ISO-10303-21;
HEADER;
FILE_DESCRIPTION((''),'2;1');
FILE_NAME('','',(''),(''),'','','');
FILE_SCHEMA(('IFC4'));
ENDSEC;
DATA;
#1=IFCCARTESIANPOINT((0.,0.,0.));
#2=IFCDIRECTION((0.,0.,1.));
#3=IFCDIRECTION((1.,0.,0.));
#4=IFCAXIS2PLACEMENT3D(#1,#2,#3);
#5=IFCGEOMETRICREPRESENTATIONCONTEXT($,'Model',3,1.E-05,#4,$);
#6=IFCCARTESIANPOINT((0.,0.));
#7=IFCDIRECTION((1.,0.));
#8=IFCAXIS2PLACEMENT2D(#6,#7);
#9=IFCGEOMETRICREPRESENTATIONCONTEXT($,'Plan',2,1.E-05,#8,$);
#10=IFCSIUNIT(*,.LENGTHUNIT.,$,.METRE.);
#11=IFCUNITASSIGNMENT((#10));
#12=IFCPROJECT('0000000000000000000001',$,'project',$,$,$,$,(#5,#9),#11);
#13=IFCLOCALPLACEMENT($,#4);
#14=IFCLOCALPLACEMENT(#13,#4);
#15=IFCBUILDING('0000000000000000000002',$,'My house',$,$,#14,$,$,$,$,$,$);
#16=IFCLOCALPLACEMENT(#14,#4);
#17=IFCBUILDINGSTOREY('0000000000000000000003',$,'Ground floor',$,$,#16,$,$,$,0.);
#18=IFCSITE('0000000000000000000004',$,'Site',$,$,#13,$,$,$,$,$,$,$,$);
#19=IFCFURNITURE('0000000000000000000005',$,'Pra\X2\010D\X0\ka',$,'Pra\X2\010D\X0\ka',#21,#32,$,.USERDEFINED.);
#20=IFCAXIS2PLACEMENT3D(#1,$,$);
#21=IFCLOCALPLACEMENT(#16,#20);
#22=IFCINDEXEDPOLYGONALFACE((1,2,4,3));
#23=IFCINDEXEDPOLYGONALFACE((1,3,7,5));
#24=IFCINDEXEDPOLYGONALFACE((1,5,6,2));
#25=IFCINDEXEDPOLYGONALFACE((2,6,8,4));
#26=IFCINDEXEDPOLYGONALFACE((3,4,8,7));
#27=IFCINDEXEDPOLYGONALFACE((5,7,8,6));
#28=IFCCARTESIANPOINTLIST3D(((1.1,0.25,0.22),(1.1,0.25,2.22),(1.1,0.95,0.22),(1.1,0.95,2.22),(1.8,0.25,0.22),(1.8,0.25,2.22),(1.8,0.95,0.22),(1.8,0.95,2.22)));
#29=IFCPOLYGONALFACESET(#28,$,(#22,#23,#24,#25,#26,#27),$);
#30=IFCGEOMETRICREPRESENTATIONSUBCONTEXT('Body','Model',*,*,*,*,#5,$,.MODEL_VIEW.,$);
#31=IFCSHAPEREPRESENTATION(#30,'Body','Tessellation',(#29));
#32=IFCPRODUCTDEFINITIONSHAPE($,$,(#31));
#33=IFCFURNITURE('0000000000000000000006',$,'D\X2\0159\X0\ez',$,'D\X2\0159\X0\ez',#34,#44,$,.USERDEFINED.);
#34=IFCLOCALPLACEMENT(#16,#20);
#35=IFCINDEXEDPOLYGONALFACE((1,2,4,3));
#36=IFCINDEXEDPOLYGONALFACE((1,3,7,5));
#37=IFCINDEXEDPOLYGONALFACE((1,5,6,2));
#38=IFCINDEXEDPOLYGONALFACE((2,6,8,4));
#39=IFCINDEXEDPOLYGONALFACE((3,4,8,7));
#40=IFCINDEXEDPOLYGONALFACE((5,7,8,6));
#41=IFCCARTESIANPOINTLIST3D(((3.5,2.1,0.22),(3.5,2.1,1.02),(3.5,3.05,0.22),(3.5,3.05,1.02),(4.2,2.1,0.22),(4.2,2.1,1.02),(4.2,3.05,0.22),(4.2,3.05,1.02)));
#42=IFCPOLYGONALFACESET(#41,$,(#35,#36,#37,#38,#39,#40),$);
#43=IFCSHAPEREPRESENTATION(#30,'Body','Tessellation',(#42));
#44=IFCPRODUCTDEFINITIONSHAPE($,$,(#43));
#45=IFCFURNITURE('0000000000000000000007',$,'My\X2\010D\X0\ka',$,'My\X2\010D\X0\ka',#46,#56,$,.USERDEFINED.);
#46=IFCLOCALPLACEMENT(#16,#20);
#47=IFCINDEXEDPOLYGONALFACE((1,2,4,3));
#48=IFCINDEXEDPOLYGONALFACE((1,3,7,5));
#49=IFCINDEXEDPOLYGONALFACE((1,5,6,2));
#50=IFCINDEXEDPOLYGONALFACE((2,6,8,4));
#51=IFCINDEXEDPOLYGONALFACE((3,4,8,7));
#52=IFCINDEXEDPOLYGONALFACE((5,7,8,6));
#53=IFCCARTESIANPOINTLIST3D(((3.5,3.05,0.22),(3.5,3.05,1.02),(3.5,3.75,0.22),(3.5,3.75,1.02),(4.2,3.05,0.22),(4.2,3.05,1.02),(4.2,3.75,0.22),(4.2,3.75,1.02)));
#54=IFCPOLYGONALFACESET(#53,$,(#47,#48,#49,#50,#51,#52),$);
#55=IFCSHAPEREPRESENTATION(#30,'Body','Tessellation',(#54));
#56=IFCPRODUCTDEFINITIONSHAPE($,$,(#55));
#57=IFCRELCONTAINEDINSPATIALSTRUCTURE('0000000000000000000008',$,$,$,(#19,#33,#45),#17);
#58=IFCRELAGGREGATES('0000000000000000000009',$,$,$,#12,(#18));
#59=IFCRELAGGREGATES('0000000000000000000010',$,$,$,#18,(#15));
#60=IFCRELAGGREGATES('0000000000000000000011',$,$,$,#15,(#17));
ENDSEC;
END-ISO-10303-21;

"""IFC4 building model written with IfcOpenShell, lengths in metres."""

from ifc_helpers import new_model, entity, si_unit, frame, origin_with_axes, origin_2d_with_axis, place, context, subcontext, project, spatial, indexed_curve, outline, extrude, shape, element, save


model = new_model("IFC4")

# Units and contexts
model_context = context("Model", 3, precision=1e-05, world=origin_with_axes())
plan_context = context("Plan", 2, precision=1e-05, world=origin_2d_with_axis())
body_context_1 = subcontext(model_context, "Body", "Model", "MODEL_VIEW")
body_context_2 = subcontext(plan_context, "Body", "Plan", "PLAN_VIEW")
ifc_project = project(units=[si_unit("LENGTHUNIT", "METRE")], contexts=[model_context, plan_context])

# Site, building, storey
site_placement = place(None, origin_with_axes())
site = spatial("IfcSite", under=ifc_project, at=site_placement, Name="Site")
building_placement = place(site_placement, origin_with_axes())
building = spatial("IfcBuilding", under=site, at=building_placement, Name="My house")
storey_placement = place(building_placement, origin_with_axes())
storey = spatial("IfcBuildingStorey", under=building, at=storey_placement, Name="Ground floor", Elevation=0.0)

# Furniture
furniture_1_placement = place(storey_placement, frame((1.45, 0.6, 0.22), z_axis=(0.0, 0.0, 1.0), x_axis=(1.0, 0.0, 0.0)))
element("IfcFurniture", 1, at=furniture_1_placement, inside=storey, Name="Pračka", ObjectType="Pračka", PredefinedType="USERDEFINED", shapes=[
    shape(body_context_1, "Body", "SweptSolid", [extrude(outline(indexed_curve([(-0.35, -0.35), (0.35, -0.35), (0.35, 0.35), (-0.35, 0.35)])), None, (0.0, 0.0, 1.0), 2.0)]),
    shape(body_context_2, "Body", "Curve2D", [entity("IfcIndexedPolyCurve", entity("IfcCartesianPointList2D", [[-0.35, -0.35], [0.35, -0.35], [0.35, 0.35], [-0.35, 0.35], [-0.35, -0.35]]), None, False)]),
])
furniture_2_placement = place(storey_placement, frame((3.85, 2.575, 0.22), z_axis=(0.0, 0.0, 1.0), x_axis=(1.0, 0.0, 0.0)))
element("IfcFurniture", 2, at=furniture_2_placement, inside=storey, Name="Dřez", ObjectType="Dřez", PredefinedType="USERDEFINED", shapes=[
    shape(body_context_1, "Body", "SweptSolid", [extrude(outline(indexed_curve([(-0.35, -0.475), (0.35, -0.475), (0.35, 0.475), (-0.35, 0.475)])), None, (0.0, 0.0, 1.0), 0.8)]),
    shape(body_context_2, "Body", "Curve2D", [entity("IfcIndexedPolyCurve", entity("IfcCartesianPointList2D", [[-0.35, -0.475], [0.35, -0.475], [0.35, 0.475], [-0.35, 0.475], [-0.35, -0.475]]), None, False)]),
])
furniture_3_placement = place(storey_placement, frame((3.85, 3.4, 0.22), z_axis=(0.0, 0.0, 1.0), x_axis=(1.0, 0.0, 0.0)))
element("IfcFurniture", 3, at=furniture_3_placement, inside=storey, Name="Myčka", ObjectType="Myčka", PredefinedType="USERDEFINED", shapes=[
    shape(body_context_1, "Body", "SweptSolid", [extrude(outline(indexed_curve([(-0.35, -0.35), (0.35, -0.35), (0.35, 0.35), (-0.35, 0.35)])), None, (0.0, 0.0, 1.0), 0.8)]),
    shape(body_context_2, "Body", "Curve2D", [entity("IfcIndexedPolyCurve", entity("IfcCartesianPointList2D", [[-0.35, -0.35], [0.35, -0.35], [0.35, 0.35], [-0.35, 0.35], [-0.35, -0.35]]), None, False)]),
])

save(model, "model.ifc")
